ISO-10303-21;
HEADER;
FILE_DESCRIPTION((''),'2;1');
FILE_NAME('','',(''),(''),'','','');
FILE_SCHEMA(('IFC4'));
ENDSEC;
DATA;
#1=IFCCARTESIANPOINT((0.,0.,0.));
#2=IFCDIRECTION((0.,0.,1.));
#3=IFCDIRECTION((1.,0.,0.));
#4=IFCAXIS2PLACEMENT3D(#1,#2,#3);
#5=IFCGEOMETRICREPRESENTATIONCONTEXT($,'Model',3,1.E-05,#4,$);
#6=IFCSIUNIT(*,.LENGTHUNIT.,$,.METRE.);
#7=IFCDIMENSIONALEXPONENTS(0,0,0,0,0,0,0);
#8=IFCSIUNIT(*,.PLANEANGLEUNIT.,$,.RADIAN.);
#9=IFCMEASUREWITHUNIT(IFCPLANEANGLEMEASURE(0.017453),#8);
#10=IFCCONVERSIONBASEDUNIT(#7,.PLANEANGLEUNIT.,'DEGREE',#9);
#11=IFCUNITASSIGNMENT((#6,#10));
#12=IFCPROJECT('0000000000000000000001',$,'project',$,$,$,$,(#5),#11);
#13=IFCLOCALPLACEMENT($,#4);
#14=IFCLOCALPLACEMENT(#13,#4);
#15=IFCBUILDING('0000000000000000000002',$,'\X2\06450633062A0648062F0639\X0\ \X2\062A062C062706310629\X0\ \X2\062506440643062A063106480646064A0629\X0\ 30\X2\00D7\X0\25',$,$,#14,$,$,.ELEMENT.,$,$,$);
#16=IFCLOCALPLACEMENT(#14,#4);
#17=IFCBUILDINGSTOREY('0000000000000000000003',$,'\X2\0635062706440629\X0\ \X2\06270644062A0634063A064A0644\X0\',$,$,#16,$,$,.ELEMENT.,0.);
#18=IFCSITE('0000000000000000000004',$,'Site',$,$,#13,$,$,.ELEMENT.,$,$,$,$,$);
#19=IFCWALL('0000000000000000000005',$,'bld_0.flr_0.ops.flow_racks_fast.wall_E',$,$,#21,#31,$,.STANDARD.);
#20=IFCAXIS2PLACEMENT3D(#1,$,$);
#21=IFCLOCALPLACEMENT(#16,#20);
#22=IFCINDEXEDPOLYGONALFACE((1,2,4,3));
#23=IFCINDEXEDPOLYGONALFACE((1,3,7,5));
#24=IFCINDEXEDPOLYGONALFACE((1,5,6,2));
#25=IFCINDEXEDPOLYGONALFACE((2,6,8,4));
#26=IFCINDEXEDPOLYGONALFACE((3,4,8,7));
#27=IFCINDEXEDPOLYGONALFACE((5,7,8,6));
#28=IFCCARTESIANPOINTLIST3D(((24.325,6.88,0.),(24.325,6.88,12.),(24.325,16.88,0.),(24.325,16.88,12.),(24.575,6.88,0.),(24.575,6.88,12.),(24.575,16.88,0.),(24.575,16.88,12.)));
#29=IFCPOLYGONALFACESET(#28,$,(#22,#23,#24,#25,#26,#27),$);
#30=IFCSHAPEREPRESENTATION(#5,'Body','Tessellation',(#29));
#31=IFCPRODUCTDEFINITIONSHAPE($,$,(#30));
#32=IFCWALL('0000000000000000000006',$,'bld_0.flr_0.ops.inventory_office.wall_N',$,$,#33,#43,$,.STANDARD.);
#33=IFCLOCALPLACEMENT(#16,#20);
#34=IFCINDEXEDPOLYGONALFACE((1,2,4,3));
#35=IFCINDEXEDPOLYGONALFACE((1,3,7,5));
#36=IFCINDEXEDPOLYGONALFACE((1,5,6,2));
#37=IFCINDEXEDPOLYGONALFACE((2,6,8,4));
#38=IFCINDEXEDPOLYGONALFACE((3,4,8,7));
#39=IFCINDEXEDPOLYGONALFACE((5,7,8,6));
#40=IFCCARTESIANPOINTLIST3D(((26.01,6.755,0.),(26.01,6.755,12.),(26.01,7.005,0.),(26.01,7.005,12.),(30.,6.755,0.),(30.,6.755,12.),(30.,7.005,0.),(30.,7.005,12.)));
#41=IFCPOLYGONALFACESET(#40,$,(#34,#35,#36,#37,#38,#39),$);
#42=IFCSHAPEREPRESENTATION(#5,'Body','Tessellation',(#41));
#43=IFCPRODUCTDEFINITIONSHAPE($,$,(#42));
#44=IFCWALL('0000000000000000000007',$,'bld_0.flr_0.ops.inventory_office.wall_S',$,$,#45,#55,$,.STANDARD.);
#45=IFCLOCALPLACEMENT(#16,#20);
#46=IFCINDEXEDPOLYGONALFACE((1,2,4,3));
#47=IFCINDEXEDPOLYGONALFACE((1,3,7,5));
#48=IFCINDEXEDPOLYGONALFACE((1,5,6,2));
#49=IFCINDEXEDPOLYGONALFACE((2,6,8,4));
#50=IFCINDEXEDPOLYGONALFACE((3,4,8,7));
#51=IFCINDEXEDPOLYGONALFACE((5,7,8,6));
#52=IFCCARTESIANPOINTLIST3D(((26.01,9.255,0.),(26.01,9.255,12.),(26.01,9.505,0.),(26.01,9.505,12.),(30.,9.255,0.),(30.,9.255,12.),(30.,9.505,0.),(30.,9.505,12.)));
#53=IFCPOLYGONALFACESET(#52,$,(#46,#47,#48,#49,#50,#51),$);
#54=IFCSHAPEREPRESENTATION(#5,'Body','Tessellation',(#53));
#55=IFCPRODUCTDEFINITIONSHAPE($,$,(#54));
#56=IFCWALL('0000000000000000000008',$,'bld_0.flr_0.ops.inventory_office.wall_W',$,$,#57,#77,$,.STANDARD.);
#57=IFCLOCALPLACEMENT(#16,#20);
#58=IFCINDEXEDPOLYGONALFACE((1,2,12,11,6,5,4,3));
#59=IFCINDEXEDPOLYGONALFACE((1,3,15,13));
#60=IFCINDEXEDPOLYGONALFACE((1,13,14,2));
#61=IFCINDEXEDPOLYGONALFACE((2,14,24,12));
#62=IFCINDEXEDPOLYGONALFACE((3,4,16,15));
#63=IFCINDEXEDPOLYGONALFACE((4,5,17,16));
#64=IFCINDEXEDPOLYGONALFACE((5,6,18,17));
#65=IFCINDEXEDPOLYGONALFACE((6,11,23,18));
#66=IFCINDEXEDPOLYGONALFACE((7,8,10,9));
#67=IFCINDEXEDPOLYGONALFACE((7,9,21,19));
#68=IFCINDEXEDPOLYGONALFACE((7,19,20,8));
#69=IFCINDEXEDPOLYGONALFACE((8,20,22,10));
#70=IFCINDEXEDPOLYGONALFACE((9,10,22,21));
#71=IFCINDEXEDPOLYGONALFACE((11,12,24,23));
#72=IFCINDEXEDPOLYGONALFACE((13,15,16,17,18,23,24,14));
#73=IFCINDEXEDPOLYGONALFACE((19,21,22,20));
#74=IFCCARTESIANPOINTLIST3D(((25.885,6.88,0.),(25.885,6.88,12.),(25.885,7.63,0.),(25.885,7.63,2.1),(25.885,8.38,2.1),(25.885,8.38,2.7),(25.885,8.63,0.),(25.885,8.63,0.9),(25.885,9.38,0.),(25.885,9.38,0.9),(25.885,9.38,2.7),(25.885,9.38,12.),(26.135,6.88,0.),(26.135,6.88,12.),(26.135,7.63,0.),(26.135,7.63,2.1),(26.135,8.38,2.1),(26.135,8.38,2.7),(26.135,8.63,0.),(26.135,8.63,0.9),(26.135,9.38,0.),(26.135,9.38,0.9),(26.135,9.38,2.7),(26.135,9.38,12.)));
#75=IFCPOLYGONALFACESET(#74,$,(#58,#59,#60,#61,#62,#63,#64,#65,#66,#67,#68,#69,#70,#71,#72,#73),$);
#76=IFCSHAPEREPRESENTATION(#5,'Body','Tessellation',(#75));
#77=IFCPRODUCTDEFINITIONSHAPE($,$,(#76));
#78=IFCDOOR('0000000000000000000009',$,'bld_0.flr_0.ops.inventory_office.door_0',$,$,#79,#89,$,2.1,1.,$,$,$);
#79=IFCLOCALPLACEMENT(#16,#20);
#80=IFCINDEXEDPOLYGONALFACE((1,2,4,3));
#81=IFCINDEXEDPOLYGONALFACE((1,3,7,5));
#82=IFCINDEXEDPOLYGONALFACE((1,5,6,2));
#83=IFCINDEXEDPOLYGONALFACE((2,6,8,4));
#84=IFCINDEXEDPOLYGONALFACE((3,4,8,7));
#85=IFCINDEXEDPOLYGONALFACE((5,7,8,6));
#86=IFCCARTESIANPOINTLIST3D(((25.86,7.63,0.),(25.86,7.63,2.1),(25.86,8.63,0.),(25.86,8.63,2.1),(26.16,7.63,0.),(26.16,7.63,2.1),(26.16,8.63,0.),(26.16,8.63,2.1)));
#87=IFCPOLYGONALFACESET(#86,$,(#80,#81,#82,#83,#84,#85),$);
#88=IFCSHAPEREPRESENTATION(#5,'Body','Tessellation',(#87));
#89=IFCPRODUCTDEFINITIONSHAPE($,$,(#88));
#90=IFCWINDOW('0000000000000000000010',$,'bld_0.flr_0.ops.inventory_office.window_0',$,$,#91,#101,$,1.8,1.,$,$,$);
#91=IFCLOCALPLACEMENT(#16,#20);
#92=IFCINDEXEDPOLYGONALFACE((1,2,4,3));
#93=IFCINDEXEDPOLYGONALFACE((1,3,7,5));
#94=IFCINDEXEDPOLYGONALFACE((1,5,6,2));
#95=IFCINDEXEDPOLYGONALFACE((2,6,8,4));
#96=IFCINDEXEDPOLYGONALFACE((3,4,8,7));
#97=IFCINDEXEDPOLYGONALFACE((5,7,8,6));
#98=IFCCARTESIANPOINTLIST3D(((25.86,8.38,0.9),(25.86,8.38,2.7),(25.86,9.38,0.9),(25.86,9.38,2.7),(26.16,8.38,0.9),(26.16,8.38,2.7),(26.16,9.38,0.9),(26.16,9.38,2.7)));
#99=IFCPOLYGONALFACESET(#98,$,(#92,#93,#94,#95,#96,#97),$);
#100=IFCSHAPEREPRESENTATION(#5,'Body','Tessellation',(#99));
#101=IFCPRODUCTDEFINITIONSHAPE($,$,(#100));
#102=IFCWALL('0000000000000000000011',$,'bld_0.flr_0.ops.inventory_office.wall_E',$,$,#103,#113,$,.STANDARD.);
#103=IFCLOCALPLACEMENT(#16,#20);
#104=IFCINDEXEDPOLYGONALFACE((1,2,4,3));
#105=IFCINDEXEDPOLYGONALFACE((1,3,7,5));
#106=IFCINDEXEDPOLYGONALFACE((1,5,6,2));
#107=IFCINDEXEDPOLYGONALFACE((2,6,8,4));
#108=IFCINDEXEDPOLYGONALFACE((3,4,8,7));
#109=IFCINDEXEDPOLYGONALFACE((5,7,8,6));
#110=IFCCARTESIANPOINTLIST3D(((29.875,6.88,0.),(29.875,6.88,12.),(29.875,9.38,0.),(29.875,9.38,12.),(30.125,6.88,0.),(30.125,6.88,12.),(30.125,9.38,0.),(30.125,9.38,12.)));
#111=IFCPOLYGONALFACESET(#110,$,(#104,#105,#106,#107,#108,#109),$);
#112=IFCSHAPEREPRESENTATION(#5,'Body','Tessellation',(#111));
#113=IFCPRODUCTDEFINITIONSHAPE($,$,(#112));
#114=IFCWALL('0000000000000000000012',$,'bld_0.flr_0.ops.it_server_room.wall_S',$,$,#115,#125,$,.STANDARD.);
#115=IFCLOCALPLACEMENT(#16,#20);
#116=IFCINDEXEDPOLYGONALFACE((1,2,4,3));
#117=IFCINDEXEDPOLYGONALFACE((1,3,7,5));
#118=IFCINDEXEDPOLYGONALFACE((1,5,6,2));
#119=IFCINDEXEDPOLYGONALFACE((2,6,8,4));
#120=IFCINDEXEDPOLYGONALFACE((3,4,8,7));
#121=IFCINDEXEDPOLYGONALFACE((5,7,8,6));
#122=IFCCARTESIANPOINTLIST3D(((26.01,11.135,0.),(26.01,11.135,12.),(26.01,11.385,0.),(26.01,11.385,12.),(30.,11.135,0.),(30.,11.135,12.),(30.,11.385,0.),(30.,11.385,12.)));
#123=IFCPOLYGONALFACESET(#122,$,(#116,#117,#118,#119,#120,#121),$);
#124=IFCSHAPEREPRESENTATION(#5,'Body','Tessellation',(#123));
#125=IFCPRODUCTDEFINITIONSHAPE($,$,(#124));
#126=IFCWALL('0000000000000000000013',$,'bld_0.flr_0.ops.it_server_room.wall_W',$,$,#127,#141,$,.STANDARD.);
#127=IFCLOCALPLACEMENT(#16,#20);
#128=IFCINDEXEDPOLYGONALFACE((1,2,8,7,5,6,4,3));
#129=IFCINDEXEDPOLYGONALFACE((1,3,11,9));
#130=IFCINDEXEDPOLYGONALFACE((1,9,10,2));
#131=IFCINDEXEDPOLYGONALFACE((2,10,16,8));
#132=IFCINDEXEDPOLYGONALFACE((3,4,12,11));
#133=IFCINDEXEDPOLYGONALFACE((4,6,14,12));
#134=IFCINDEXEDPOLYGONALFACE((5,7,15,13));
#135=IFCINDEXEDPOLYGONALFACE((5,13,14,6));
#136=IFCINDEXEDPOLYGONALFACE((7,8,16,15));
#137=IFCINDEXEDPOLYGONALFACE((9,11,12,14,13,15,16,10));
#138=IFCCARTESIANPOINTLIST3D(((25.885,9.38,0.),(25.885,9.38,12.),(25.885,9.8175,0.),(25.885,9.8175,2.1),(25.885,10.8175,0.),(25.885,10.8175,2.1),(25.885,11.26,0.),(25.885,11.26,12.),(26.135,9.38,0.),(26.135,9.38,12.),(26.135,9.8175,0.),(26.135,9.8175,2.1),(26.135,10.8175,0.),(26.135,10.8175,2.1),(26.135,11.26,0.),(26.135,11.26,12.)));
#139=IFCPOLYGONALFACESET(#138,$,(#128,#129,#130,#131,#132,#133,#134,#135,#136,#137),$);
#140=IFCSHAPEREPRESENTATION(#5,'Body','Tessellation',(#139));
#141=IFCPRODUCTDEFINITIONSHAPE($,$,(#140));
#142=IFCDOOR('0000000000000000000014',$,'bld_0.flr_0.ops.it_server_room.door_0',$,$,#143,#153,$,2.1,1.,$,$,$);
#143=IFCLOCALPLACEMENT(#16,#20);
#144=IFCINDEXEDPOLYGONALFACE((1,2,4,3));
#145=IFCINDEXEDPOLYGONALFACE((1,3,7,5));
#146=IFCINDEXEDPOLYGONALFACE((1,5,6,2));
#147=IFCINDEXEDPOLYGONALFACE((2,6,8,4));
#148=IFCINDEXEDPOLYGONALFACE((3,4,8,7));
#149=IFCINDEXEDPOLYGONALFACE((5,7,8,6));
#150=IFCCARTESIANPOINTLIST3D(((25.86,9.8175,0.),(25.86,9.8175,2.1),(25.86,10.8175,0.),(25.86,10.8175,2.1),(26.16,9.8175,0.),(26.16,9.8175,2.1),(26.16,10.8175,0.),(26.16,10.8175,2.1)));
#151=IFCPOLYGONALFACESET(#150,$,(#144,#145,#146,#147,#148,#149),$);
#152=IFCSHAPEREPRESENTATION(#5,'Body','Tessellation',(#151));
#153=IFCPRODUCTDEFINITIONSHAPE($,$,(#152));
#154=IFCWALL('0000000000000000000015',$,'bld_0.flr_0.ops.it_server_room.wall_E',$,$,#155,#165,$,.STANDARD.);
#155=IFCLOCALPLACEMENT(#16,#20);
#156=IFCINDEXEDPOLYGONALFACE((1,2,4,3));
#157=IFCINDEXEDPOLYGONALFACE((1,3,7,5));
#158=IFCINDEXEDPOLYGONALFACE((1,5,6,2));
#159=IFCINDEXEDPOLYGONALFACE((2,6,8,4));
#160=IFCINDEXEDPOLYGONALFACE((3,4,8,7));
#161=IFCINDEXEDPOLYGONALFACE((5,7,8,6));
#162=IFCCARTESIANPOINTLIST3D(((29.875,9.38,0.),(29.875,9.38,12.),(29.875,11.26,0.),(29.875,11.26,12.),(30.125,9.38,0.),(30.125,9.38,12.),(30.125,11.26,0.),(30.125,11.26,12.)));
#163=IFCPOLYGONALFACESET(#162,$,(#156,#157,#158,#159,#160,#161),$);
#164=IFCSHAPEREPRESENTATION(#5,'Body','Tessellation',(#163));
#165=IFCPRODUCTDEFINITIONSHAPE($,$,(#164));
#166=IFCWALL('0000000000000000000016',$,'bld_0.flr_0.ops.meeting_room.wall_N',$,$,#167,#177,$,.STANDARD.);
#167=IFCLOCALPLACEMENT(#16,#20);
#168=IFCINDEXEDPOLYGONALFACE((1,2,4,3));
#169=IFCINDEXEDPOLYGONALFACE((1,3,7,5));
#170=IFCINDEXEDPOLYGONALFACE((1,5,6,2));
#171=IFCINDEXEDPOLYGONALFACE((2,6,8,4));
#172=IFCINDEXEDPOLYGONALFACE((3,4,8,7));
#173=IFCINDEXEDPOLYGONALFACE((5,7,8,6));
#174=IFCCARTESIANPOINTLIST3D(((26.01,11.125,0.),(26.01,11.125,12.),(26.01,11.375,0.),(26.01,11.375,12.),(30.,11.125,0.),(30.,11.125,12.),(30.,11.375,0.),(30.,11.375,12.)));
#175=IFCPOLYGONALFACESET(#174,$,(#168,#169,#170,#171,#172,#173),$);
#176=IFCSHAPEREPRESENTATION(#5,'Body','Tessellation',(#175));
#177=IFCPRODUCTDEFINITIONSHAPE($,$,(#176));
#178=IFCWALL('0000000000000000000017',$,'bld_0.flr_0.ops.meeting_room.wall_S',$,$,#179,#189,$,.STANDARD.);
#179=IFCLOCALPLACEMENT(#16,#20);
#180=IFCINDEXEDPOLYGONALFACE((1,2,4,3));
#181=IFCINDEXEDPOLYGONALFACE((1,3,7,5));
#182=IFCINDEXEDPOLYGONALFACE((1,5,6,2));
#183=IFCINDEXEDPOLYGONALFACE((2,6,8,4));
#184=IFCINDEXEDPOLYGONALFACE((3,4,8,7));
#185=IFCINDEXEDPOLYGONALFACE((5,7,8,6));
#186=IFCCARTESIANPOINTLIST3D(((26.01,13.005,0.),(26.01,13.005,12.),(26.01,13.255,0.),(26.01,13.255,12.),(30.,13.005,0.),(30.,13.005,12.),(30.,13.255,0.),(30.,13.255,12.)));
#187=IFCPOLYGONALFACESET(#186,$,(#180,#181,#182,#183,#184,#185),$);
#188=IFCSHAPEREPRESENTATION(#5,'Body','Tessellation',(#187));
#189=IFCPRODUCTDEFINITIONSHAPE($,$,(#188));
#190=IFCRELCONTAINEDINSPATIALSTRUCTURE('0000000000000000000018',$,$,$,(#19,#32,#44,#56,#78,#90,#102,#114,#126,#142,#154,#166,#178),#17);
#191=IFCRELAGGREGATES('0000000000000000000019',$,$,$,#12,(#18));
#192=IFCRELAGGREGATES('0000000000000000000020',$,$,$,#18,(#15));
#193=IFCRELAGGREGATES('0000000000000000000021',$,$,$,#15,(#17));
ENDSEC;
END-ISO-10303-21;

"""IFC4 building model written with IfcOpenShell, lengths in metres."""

from ifc_helpers import new_model, entity, si_unit, converted_unit, frame, frame_2d, origin_with_axes, origin_2d_with_axis, place, context, project, spatial, rectangle, extrude, element, fill, save


model = new_model("IFC4")

# Units and contexts
model_context = context("Model", 3, precision=1e-05, world=origin_with_axes())
ifc_project = project(units=[si_unit("LENGTHUNIT", "METRE"), converted_unit("PLANEANGLEUNIT", "DEGREE", entity("IfcPlaneAngleMeasure", 0.017453), si_unit("PLANEANGLEUNIT", "RADIAN"), dimensions=[0, 0, 0, 0, 0, 0, 0])], contexts=[model_context])

# Site, building, storey
site_placement = place(None, origin_with_axes())
site = spatial("IfcSite", under=ifc_project, at=site_placement, Name="Site", CompositionType="ELEMENT")
building_placement = place(site_placement, origin_with_axes())
building = spatial("IfcBuilding", under=site, at=building_placement, Name="مستودع تجارة إلكترونية 30×25", CompositionType="ELEMENT")
storey_placement = place(building_placement, origin_with_axes())
storey = spatial("IfcBuildingStorey", under=building, at=storey_placement, Name="صالة التشغيل", CompositionType="ELEMENT", Elevation=0.0)

# Walls
wall_1_placement = place(storey_placement, frame((24.45, 6.88, 0.0), z_axis=(0.0, 0.0, 1.0), x_axis=(0.0, 1.0, 0.0)))
element("IfcWall", 1, at=wall_1_placement, inside=storey, Name="bld_0.flr_0.ops.flow_racks_fast.wall_E", PredefinedType="STANDARD", context=model_context, shape_type="SweptSolid", body=[
    extrude(rectangle(XDim=10.0, YDim=0.25, at=frame_2d((5.0, 0.0), x_axis=(1.0, 0.0))), origin_with_axes(), (0.0, 0.0, 1.0), 12.0),
])
for number, where, z_axis, x_axis, name in (
    (2, (26.01, 6.88, 0.0), (0.0, 0.0, 1.0), (1.0, 0.0, 0.0), "bld_0.flr_0.ops.inventory_office.wall_N"),
    (3, (26.01, 9.38, 0.0), (0.0, 0.0, 1.0), (1.0, 0.0, 0.0), "bld_0.flr_0.ops.inventory_office.wall_S"),
):
    element("IfcWall", number, at=place(storey_placement, frame(where, z_axis=z_axis, x_axis=x_axis)), inside=storey, Name=name, PredefinedType="STANDARD", context=model_context, shape_type="SweptSolid", body=[
        extrude(rectangle(XDim=3.99, YDim=0.25, at=frame_2d((1.995, 0.0), x_axis=(1.0, 0.0))), origin_with_axes(), (0.0, 0.0, 1.0), 12.0),
    ])

# Wall, openings, door, window
wall_2_placement = place(storey_placement, frame((26.01, 6.88, 0.0), z_axis=(0.0, 0.0, 1.0), x_axis=(0.0, 1.0, 0.0)))
wall_2 = element("IfcWall", 4, at=wall_2_placement, inside=storey, Name="bld_0.flr_0.ops.inventory_office.wall_W", PredefinedType="STANDARD", context=model_context, shape_type="SweptSolid", body=[
    extrude(rectangle(XDim=2.5, YDim=0.25, at=frame_2d((1.25, 0.0), x_axis=(1.0, 0.0))), origin_with_axes(), (0.0, 0.0, 1.0), 12.0),
])
opening_1_placement = place(storey_placement, frame((26.01, 8.13, 0.0), z_axis=(0.0, 0.0, 1.0), x_axis=(0.0, 1.0, 0.0)))
opening_1 = element("IfcOpeningElement", 5, at=opening_1_placement, cuts=wall_2, PredefinedType="OPENING", context=model_context, shape_type="SweptSolid", body=[
    extrude(rectangle(XDim=1.0, YDim=0.3, at=origin_2d_with_axis()), origin_with_axes(), (0.0, 0.0, 1.0), 2.1),
])
opening_2_placement = place(storey_placement, frame((26.01, 8.88, 0.9), z_axis=(0.0, 0.0, 1.0), x_axis=(0.0, 1.0, 0.0)))
opening_2 = element("IfcOpeningElement", 6, at=opening_2_placement, cuts=wall_2, PredefinedType="OPENING", context=model_context, shape_type="SweptSolid", body=[
    extrude(rectangle(XDim=1.0, YDim=0.3, at=origin_2d_with_axis()), origin_with_axes(), (0.0, 0.0, 1.0), 1.8),
])
door_1_placement = place(storey_placement, frame((26.01, 8.13, 0.0), z_axis=(0.0, 0.0, 1.0), x_axis=(0.0, 1.0, 0.0)))
door_1 = element("IfcDoor", 7, at=door_1_placement, inside=storey, Name="bld_0.flr_0.ops.inventory_office.door_0", OverallHeight=2.1, OverallWidth=1.0, context=model_context, shape_type="SweptSolid", body=[
    extrude(rectangle(XDim=1.0, YDim=0.3, at=origin_2d_with_axis()), origin_with_axes(), (0.0, 0.0, 1.0), 2.1),
])
fill(opening_1, door_1)
window_placement = place(storey_placement, frame((26.01, 8.88, 0.9), z_axis=(0.0, 0.0, 1.0), x_axis=(0.0, 1.0, 0.0)))
window = element("IfcWindow", 8, at=window_placement, inside=storey, Name="bld_0.flr_0.ops.inventory_office.window_0", OverallHeight=1.8, OverallWidth=1.0, context=model_context, shape_type="SweptSolid", body=[
    extrude(rectangle(XDim=1.0, YDim=0.3, at=origin_2d_with_axis()), origin_with_axes(), (0.0, 0.0, 1.0), 1.8),
])
fill(opening_2, window)

# Walls
wall_3_placement = place(storey_placement, frame((30.0, 6.88, 0.0), z_axis=(0.0, 0.0, 1.0), x_axis=(0.0, 1.0, 0.0)))
element("IfcWall", 9, at=wall_3_placement, inside=storey, Name="bld_0.flr_0.ops.inventory_office.wall_E", PredefinedType="STANDARD", context=model_context, shape_type="SweptSolid", body=[
    extrude(rectangle(XDim=2.5, YDim=0.25, at=frame_2d((1.25, 0.0), x_axis=(1.0, 0.0))), origin_with_axes(), (0.0, 0.0, 1.0), 12.0),
])
for number, where, z_axis, x_axis, name in (
    (10, (26.01, 11.26, 0.0), (0.0, 0.0, 1.0), (1.0, 0.0, 0.0), "bld_0.flr_0.ops.it_server_room.wall_S"),
):
    element("IfcWall", number, at=place(storey_placement, frame(where, z_axis=z_axis, x_axis=x_axis)), inside=storey, Name=name, PredefinedType="STANDARD", context=model_context, shape_type="SweptSolid", body=[
        extrude(rectangle(XDim=3.99, YDim=0.25, at=frame_2d((1.995, 0.0), x_axis=(1.0, 0.0))), origin_with_axes(), (0.0, 0.0, 1.0), 12.0),
    ])

# Wall, opening, door
wall_4_placement = place(storey_placement, frame((26.01, 9.38, 0.0), z_axis=(0.0, 0.0, 1.0), x_axis=(0.0, 1.0, 0.0)))
wall_4 = element("IfcWall", 11, at=wall_4_placement, inside=storey, Name="bld_0.flr_0.ops.it_server_room.wall_W", PredefinedType="STANDARD", context=model_context, shape_type="SweptSolid", body=[
    extrude(rectangle(XDim=1.88, YDim=0.25, at=frame_2d((0.94, 0.0), x_axis=(1.0, 0.0))), origin_with_axes(), (0.0, 0.0, 1.0), 12.0),
])
opening_3_placement = place(storey_placement, frame((26.01, 10.3175, 0.0), z_axis=(0.0, 0.0, 1.0), x_axis=(0.0, 1.0, 0.0)))
opening_3 = element("IfcOpeningElement", 12, at=opening_3_placement, cuts=wall_4, PredefinedType="OPENING", context=model_context, shape_type="SweptSolid", body=[
    extrude(rectangle(XDim=1.0, YDim=0.3, at=origin_2d_with_axis()), origin_with_axes(), (0.0, 0.0, 1.0), 2.1),
])
door_2_placement = place(storey_placement, frame((26.01, 10.3175, 0.0), z_axis=(0.0, 0.0, 1.0), x_axis=(0.0, 1.0, 0.0)))
door_2 = element("IfcDoor", 13, at=door_2_placement, inside=storey, Name="bld_0.flr_0.ops.it_server_room.door_0", OverallHeight=2.1, OverallWidth=1.0, context=model_context, shape_type="SweptSolid", body=[
    extrude(rectangle(XDim=1.0, YDim=0.3, at=origin_2d_with_axis()), origin_with_axes(), (0.0, 0.0, 1.0), 2.1),
])
fill(opening_3, door_2)

# Walls
wall_5_placement = place(storey_placement, frame((30.0, 9.38, 0.0), z_axis=(0.0, 0.0, 1.0), x_axis=(0.0, 1.0, 0.0)))
element("IfcWall", 14, at=wall_5_placement, inside=storey, Name="bld_0.flr_0.ops.it_server_room.wall_E", PredefinedType="STANDARD", context=model_context, shape_type="SweptSolid", body=[
    extrude(rectangle(XDim=1.88, YDim=0.25, at=frame_2d((0.94, 0.0), x_axis=(1.0, 0.0))), origin_with_axes(), (0.0, 0.0, 1.0), 12.0),
])
for number, where, z_axis, x_axis, name in (
    (15, (26.01, 11.25, 0.0), (0.0, 0.0, 1.0), (1.0, 0.0, 0.0), "bld_0.flr_0.ops.meeting_room.wall_N"),
    (16, (26.01, 13.13, 0.0), (0.0, 0.0, 1.0), (1.0, 0.0, 0.0), "bld_0.flr_0.ops.meeting_room.wall_S"),
):
    element("IfcWall", number, at=place(storey_placement, frame(where, z_axis=z_axis, x_axis=x_axis)), inside=storey, Name=name, PredefinedType="STANDARD", context=model_context, shape_type="SweptSolid", body=[
        extrude(rectangle(XDim=3.99, YDim=0.25, at=frame_2d((1.995, 0.0), x_axis=(1.0, 0.0))), origin_with_axes(), (0.0, 0.0, 1.0), 12.0),
    ])

save(model, "model.ifc")
